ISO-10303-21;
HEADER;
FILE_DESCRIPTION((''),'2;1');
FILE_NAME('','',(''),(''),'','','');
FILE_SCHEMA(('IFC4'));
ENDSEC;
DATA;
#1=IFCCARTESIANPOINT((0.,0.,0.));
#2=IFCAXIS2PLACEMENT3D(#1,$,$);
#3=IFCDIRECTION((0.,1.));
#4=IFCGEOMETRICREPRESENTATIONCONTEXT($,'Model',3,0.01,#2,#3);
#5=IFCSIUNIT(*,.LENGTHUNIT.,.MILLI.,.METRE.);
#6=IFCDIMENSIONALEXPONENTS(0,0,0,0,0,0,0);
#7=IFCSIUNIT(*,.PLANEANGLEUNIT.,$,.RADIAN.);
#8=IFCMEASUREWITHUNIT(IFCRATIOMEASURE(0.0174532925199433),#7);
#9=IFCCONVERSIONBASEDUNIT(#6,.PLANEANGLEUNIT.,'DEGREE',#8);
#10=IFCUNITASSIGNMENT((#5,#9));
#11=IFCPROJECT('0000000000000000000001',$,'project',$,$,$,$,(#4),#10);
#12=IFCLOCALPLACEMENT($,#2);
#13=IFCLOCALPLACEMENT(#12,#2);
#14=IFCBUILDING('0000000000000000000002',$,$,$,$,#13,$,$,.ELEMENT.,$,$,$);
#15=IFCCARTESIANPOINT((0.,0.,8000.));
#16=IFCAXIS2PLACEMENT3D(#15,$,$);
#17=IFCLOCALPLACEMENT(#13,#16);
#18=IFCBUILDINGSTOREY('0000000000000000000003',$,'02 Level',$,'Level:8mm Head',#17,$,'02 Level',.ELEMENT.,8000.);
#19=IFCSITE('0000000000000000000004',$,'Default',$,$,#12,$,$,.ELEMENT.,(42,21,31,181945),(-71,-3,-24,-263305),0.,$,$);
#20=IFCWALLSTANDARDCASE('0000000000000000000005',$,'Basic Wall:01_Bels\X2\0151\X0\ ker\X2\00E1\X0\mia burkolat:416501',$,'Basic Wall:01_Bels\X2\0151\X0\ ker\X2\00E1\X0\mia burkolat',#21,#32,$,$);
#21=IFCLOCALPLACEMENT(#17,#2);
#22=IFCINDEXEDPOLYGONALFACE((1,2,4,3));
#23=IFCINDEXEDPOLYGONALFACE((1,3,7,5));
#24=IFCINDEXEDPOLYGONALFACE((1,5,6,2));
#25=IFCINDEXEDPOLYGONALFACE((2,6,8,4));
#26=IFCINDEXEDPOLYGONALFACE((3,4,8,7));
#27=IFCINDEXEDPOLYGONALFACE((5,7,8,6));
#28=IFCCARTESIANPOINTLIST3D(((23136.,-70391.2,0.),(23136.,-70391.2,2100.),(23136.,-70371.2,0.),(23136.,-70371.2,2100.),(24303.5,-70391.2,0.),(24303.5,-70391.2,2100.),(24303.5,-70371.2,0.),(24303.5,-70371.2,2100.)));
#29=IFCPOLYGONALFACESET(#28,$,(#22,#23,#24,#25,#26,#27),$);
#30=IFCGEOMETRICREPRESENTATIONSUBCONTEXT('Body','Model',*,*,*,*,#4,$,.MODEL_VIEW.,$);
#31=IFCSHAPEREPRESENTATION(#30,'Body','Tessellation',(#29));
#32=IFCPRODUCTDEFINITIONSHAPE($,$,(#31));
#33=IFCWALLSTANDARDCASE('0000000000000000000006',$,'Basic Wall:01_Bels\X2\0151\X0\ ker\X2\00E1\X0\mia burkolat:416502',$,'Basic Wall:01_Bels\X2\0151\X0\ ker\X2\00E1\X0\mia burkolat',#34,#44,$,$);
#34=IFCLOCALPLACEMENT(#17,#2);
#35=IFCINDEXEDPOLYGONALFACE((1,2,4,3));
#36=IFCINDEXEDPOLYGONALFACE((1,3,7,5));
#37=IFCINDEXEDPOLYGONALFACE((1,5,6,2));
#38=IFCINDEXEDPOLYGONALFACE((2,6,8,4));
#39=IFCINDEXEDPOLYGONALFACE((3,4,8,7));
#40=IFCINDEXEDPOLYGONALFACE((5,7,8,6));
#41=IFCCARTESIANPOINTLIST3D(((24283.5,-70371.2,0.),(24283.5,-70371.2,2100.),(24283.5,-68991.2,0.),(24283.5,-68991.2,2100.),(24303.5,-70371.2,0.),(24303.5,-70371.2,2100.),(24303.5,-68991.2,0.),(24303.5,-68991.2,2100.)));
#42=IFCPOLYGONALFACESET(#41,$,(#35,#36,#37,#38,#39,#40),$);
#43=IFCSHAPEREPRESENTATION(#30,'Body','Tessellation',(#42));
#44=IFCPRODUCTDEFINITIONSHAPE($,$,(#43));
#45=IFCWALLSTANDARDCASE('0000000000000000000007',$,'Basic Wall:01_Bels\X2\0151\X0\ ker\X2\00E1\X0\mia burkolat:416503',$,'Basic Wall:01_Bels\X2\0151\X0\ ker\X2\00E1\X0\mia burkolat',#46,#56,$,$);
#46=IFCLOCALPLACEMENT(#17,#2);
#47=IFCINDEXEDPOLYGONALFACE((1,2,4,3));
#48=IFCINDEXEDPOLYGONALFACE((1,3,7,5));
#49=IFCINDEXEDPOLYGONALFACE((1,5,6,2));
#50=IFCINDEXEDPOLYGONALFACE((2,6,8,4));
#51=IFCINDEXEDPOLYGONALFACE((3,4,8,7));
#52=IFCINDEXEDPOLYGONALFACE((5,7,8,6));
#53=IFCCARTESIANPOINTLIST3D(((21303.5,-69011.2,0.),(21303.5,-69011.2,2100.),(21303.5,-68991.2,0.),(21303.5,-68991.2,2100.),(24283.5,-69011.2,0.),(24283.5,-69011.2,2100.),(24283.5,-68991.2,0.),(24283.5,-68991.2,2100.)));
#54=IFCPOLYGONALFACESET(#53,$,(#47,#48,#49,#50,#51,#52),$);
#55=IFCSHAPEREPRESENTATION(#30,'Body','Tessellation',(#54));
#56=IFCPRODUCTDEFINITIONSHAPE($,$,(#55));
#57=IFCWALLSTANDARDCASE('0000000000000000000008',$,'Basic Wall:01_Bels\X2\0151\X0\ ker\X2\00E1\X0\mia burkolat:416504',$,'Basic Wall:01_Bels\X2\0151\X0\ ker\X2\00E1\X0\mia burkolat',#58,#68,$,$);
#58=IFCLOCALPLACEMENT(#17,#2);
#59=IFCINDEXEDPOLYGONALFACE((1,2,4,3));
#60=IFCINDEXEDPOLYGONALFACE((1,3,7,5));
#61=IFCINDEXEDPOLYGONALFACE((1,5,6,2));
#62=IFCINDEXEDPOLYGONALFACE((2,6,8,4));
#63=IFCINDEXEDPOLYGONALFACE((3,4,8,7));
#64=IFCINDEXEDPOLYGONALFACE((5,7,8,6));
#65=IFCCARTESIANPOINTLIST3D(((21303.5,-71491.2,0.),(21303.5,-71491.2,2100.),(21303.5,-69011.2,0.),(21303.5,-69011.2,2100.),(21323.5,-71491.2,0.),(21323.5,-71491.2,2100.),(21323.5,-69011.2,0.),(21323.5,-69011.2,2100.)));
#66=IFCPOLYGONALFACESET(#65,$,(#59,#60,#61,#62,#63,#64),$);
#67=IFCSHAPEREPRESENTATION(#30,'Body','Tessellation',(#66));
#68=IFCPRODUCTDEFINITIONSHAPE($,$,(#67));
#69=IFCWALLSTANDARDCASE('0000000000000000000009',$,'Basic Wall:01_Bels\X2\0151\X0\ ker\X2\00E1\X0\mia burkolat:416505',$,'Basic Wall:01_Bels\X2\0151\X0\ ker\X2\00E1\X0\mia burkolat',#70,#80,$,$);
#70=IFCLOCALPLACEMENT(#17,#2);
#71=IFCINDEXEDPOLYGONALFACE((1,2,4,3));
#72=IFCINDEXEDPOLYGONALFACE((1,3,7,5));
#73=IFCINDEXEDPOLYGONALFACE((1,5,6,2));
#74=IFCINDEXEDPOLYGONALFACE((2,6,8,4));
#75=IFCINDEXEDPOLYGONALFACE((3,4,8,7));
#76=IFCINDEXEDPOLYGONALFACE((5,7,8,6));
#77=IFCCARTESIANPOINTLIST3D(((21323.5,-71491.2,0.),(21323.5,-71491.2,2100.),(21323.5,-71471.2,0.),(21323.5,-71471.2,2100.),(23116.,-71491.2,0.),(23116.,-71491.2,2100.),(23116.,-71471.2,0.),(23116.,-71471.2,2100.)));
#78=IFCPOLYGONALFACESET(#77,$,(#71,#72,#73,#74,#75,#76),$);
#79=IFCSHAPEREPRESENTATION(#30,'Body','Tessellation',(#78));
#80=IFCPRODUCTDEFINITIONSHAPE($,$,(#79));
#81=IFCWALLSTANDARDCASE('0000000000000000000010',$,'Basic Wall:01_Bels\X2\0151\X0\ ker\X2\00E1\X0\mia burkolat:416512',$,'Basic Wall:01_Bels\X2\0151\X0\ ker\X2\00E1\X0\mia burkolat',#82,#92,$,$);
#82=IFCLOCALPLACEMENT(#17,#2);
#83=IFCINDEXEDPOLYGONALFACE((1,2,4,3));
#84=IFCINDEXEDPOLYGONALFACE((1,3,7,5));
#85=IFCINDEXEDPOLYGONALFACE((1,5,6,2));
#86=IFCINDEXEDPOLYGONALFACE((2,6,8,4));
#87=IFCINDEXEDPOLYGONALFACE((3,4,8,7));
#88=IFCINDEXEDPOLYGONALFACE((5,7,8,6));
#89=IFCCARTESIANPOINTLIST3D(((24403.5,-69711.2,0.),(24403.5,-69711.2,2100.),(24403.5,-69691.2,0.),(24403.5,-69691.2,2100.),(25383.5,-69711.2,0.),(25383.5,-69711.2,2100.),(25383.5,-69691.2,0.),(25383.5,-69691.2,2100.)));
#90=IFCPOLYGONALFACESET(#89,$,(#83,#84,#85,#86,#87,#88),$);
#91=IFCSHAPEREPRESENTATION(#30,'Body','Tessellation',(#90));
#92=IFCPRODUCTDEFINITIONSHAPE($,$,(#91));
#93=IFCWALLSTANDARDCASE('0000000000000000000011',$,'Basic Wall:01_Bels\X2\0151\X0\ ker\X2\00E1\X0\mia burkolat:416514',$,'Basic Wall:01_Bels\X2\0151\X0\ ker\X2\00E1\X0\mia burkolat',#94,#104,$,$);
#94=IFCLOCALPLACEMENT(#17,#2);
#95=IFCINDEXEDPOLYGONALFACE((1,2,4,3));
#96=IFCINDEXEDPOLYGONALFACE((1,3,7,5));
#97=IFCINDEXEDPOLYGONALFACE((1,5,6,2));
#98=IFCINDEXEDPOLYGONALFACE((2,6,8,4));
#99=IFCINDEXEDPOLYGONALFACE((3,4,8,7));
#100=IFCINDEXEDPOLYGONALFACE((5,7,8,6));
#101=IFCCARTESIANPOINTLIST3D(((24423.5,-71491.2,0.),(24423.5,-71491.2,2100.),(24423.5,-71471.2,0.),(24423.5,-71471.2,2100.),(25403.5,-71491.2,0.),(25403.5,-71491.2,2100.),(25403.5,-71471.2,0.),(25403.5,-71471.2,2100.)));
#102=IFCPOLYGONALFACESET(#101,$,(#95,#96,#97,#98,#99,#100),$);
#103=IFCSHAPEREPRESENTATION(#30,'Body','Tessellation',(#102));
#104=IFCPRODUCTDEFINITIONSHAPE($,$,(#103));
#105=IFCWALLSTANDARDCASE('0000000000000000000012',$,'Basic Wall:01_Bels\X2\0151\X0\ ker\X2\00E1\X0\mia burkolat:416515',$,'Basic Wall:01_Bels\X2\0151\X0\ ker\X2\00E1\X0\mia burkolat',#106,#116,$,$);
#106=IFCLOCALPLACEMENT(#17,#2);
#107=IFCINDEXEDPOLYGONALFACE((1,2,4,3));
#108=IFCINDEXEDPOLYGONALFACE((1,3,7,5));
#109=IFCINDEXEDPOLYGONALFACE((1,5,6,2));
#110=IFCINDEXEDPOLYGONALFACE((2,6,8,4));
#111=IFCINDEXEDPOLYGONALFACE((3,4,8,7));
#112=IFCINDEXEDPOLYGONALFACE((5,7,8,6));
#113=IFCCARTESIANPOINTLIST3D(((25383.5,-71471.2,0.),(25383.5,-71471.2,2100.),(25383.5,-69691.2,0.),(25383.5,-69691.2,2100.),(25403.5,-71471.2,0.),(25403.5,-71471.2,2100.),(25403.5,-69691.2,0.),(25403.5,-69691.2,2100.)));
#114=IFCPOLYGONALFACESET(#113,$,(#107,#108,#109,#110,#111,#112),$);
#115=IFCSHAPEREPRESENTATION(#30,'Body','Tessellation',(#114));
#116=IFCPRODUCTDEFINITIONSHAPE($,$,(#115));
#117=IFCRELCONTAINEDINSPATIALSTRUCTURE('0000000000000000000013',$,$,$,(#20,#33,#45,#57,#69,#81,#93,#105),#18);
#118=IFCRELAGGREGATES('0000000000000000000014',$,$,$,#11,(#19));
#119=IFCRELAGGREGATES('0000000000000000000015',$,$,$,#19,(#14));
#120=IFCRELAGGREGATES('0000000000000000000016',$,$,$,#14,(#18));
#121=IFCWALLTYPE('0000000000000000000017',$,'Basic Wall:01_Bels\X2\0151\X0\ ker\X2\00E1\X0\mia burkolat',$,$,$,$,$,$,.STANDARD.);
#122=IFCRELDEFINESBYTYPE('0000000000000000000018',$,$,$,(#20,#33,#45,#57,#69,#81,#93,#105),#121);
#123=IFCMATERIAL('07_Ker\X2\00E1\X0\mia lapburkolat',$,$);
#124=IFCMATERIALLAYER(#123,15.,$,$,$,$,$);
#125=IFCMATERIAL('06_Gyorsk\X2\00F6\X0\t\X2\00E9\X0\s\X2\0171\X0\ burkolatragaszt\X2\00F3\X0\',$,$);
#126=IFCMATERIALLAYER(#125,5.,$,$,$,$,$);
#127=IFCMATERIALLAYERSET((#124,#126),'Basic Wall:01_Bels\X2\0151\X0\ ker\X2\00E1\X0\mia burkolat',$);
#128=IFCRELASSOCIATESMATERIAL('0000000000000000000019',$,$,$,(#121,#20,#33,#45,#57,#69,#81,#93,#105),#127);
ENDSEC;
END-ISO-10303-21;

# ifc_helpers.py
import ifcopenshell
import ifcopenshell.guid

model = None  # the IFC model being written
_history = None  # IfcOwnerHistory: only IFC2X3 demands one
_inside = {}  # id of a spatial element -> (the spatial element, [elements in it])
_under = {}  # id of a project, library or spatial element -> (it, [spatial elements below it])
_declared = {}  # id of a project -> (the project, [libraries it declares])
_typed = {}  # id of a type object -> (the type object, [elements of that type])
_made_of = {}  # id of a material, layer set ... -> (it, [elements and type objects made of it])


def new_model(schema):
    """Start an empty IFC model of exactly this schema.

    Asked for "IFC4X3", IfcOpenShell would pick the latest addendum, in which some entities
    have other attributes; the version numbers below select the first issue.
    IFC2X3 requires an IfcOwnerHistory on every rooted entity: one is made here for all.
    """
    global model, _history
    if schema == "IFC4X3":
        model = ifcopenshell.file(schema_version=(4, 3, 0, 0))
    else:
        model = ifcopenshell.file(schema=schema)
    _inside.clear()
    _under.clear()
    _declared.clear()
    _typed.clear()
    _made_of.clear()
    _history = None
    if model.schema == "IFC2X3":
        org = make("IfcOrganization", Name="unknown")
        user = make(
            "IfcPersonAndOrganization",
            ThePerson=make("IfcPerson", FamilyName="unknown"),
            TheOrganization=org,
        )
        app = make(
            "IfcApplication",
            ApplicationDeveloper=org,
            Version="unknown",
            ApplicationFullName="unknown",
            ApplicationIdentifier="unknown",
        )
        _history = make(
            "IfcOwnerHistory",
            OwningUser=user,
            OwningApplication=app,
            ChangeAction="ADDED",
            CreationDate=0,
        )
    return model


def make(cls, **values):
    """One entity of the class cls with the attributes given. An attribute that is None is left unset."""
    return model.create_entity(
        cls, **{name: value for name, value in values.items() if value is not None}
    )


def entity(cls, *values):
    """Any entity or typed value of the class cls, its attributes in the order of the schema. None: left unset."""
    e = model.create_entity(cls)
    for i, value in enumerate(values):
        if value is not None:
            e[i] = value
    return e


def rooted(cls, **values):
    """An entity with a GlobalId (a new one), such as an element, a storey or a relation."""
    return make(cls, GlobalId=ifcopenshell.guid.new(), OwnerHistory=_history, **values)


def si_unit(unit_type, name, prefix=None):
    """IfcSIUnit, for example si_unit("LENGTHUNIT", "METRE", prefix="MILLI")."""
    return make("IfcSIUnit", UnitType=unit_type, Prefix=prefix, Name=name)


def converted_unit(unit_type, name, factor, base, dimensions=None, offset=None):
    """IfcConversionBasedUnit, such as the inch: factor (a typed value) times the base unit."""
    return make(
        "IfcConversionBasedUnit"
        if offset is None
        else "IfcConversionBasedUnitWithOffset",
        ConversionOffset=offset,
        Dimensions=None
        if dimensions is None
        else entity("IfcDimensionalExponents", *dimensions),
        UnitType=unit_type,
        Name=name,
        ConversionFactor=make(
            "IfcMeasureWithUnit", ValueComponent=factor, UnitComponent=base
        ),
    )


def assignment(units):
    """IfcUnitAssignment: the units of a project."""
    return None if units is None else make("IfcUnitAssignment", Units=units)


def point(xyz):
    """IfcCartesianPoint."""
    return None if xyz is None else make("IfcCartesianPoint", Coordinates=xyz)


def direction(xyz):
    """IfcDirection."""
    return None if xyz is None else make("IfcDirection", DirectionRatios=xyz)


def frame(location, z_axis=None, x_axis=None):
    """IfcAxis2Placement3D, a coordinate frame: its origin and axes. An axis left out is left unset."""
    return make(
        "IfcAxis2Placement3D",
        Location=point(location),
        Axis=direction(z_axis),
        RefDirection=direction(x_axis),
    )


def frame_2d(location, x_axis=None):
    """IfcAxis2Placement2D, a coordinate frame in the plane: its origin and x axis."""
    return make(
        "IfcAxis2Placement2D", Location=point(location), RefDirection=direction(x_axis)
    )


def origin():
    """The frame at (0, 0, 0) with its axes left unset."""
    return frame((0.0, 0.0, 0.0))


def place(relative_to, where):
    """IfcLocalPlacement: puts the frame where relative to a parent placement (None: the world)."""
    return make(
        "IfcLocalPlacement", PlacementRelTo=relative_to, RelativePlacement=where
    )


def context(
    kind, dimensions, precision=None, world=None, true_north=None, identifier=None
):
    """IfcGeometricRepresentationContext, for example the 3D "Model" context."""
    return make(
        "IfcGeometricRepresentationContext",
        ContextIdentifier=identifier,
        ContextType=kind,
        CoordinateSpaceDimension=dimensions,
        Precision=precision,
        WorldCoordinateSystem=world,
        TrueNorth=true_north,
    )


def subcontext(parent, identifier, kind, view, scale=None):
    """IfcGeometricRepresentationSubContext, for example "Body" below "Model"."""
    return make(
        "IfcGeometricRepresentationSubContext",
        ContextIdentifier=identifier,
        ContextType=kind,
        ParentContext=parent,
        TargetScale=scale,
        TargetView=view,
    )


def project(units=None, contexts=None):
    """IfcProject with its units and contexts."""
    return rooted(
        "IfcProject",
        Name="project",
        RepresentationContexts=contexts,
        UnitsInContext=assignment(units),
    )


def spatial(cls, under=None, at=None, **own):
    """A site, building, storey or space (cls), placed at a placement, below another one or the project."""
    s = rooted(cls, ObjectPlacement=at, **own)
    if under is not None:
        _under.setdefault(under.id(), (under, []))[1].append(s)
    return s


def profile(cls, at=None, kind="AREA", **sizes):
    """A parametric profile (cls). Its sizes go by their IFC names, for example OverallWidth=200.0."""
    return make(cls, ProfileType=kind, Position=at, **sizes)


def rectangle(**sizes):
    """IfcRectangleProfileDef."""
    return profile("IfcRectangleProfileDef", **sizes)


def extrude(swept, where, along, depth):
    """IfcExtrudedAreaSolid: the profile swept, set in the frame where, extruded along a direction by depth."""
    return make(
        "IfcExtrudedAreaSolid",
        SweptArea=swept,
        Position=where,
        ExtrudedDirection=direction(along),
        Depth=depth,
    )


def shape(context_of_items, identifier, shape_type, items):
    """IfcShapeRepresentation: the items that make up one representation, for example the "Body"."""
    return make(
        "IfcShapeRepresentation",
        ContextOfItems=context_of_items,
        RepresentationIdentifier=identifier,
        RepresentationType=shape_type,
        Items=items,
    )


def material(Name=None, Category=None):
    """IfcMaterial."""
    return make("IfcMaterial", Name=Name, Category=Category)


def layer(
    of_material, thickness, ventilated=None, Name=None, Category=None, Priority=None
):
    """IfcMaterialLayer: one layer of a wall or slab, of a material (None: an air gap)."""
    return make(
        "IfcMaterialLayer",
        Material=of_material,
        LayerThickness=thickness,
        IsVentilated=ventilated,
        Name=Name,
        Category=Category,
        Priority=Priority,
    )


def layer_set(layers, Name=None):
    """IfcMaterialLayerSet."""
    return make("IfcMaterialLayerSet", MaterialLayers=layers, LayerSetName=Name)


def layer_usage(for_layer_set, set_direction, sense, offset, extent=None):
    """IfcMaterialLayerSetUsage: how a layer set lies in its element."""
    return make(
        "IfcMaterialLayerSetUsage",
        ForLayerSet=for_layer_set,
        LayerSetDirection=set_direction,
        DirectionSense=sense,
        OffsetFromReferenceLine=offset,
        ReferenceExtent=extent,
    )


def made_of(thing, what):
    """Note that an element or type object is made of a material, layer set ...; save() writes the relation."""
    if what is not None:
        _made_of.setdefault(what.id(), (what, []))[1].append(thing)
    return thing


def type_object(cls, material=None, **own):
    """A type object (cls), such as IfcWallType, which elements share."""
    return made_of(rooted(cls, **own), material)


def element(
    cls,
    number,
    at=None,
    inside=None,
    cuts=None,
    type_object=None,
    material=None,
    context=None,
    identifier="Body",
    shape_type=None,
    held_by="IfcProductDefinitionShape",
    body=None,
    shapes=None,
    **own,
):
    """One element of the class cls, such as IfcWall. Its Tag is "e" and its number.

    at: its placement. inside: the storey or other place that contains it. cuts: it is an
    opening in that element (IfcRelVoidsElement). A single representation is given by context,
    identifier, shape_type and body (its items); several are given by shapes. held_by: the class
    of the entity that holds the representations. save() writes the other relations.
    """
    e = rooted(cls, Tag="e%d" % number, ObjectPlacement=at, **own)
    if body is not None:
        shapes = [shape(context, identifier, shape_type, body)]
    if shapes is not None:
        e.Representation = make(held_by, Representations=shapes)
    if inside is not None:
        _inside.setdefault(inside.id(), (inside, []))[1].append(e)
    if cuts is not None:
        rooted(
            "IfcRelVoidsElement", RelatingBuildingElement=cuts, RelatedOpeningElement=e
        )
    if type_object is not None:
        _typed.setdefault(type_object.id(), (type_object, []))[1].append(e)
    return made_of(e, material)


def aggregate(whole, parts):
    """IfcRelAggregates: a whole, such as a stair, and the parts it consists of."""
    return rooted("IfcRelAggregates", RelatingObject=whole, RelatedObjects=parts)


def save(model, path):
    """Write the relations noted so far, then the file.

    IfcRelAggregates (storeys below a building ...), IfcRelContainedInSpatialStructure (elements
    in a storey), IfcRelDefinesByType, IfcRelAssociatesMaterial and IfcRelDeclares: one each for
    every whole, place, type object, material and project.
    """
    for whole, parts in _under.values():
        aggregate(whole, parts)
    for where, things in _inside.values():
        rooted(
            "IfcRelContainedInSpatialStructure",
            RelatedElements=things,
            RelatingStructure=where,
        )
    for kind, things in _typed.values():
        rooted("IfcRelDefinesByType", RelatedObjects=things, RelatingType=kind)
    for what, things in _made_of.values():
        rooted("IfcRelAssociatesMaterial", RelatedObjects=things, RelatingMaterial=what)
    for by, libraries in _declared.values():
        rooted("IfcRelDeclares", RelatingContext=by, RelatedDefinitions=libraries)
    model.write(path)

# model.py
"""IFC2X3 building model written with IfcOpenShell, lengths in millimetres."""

from ifc_helpers import new_model, entity, si_unit, converted_unit, direction, frame, frame_2d, origin, place, context, subcontext, project, spatial, rectangle, extrude, material, layer, layer_set, layer_usage, type_object, element, save


model = new_model("IFC2X3")

# Units and contexts
model_context = context("Model", 3, precision=0.01, world=origin(), true_north=direction((0.0, 1.0)))
body_context = subcontext(model_context, "Body", "Model", "MODEL_VIEW")
ifc_project = project(units=[si_unit("LENGTHUNIT", "METRE", prefix="MILLI"), converted_unit("PLANEANGLEUNIT", "DEGREE", entity("IfcRatioMeasure", 0.0174532925199433), si_unit("PLANEANGLEUNIT", "RADIAN"), dimensions=[0, 0, 0, 0, 0, 0, 0])], contexts=[model_context])

# Site, building, storey
site_placement = place(None, origin())
site = spatial("IfcSite", under=ifc_project, at=site_placement, Name="Default", CompositionType="ELEMENT", RefLatitude=(42, 21, 31, 181945), RefLongitude=(-71, -3, -24, -263305), RefElevation=0.0)
building_placement = place(site_placement, origin())
building = spatial("IfcBuilding", under=site, at=building_placement, CompositionType="ELEMENT")
storey_placement = place(building_placement, frame((0.0, 0.0, 8000.0)))
storey = spatial("IfcBuildingStorey", under=building, at=storey_placement, Name="02 Level", ObjectType="Level:8mm Head", LongName="02 Level", CompositionType="ELEMENT", Elevation=8000.0)

# Shared definitions
ifc_material_1 = material(Name="07_Kerámia lapburkolat")
ifc_layer_1 = layer(ifc_material_1, 15.0)
ifc_material_2 = material(Name="06_Gyorskötésű burkolatragasztó")
ifc_layer_2 = layer(ifc_material_2, 5.0)
ifc_layer_set_1 = layer_set([ifc_layer_1, ifc_layer_2], Name="Basic Wall:01_Belső kerámia burkolat")
wall_type_1 = type_object("IfcWallType", Name="Basic Wall:01_Belső kerámia burkolat", PredefinedType="STANDARD", material=ifc_layer_set_1)

# Walls
ifc_layer_usage_1 = layer_usage(ifc_layer_set_1, "AXIS2", "NEGATIVE", 10.0)
wall_1_placement = place(storey_placement, frame((23136.0, -70381.2, 0.0)))
element("IfcWallStandardCase", 1, at=wall_1_placement, inside=storey, type_object=wall_type_1, material=ifc_layer_usage_1, Name="Basic Wall:01_Belső kerámia burkolat:416501", ObjectType="Basic Wall:01_Belső kerámia burkolat", context=body_context, shape_type="SweptSolid", body=[
    extrude(rectangle(XDim=1167.5, YDim=20.0, at=frame_2d((583.7, 0.0), x_axis=(-1.0, 0.0))), origin(), (0.0, 0.0, 1.0), 2100.0),
])
ifc_layer_usage_2 = layer_usage(ifc_layer_set_1, "AXIS2", "NEGATIVE", 10.0)
wall_2_placement = place(storey_placement, frame((24293.5, -70371.2, 0.0), z_axis=(0.0, 0.0, 1.0), x_axis=(0.0, 1.0, 0.0)))
element("IfcWallStandardCase", 2, at=wall_2_placement, inside=storey, type_object=wall_type_1, material=ifc_layer_usage_2, Name="Basic Wall:01_Belső kerámia burkolat:416502", ObjectType="Basic Wall:01_Belső kerámia burkolat", context=body_context, shape_type="SweptSolid", body=[
    extrude(rectangle(XDim=1380.0, YDim=20.0, at=frame_2d((690.0, 0.0), x_axis=(-1.0, 0.0))), origin(), (0.0, 0.0, 1.0), 2100.0),
])
ifc_layer_usage_3 = layer_usage(ifc_layer_set_1, "AXIS2", "NEGATIVE", 10.0)
wall_3_placement = place(storey_placement, frame((24283.5, -69001.2, 0.0), z_axis=(0.0, 0.0, 1.0), x_axis=(-1.0, 0.0, 0.0)))
element("IfcWallStandardCase", 3, at=wall_3_placement, inside=storey, type_object=wall_type_1, material=ifc_layer_usage_3, Name="Basic Wall:01_Belső kerámia burkolat:416503", ObjectType="Basic Wall:01_Belső kerámia burkolat", context=body_context, shape_type="SweptSolid", body=[
    extrude(rectangle(XDim=2980.0, YDim=20.0, at=frame_2d((1490.0, 0.0), x_axis=(-1.0, 0.0))), origin(), (0.0, 0.0, 1.0), 2100.0),
])
ifc_layer_usage_4 = layer_usage(ifc_layer_set_1, "AXIS2", "NEGATIVE", 10.0)
wall_4_placement = place(storey_placement, frame((21313.5, -69011.2, 0.0), z_axis=(0.0, 0.0, 1.0), x_axis=(0.0, -1.0, 0.0)))
element("IfcWallStandardCase", 4, at=wall_4_placement, inside=storey, type_object=wall_type_1, material=ifc_layer_usage_4, Name="Basic Wall:01_Belső kerámia burkolat:416504", ObjectType="Basic Wall:01_Belső kerámia burkolat", context=body_context, shape_type="SweptSolid", body=[
    extrude(rectangle(XDim=2480.0, YDim=20.0, at=frame_2d((1240.0, 0.0), x_axis=(-1.0, 0.0))), origin(), (0.0, 0.0, 1.0), 2100.0),
])
ifc_layer_usage_5 = layer_usage(ifc_layer_set_1, "AXIS2", "NEGATIVE", 10.0)
wall_5_placement = place(storey_placement, frame((21323.5, -71481.2, 0.0)))
element("IfcWallStandardCase", 5, at=wall_5_placement, inside=storey, type_object=wall_type_1, material=ifc_layer_usage_5, Name="Basic Wall:01_Belső kerámia burkolat:416505", ObjectType="Basic Wall:01_Belső kerámia burkolat", context=body_context, shape_type="SweptSolid", body=[
    extrude(rectangle(XDim=1792.5, YDim=20.0, at=frame_2d((896.3, 0.0), x_axis=(-1.0, 0.0))), origin(), (0.0, 0.0, 1.0), 2100.0),
])
ifc_layer_usage_6 = layer_usage(ifc_layer_set_1, "AXIS2", "POSITIVE", -10.0)
wall_6_placement = place(storey_placement, frame((24403.5, -69701.2, 0.0)))
element("IfcWallStandardCase", 6, at=wall_6_placement, inside=storey, type_object=wall_type_1, material=ifc_layer_usage_6, Name="Basic Wall:01_Belső kerámia burkolat:416512", ObjectType="Basic Wall:01_Belső kerámia burkolat", context=body_context, shape_type="SweptSolid", body=[
    extrude(rectangle(XDim=980.0, YDim=20.0, at=frame_2d((490.0, 0.0), x_axis=(-1.0, 0.0))), origin(), (0.0, 0.0, 1.0), 2100.0),
])

# Walls
ifc_layer_usage_7 = layer_usage(ifc_layer_set_1, "AXIS2", "POSITIVE", -10.0)
wall_7_placement = place(storey_placement, frame((25403.5, -71481.2, 0.0), z_axis=(0.0, 0.0, 1.0), x_axis=(-1.0, 0.0, 0.0)))
element("IfcWallStandardCase", 7, at=wall_7_placement, inside=storey, type_object=wall_type_1, material=ifc_layer_usage_7, Name="Basic Wall:01_Belső kerámia burkolat:416514", ObjectType="Basic Wall:01_Belső kerámia burkolat", context=body_context, shape_type="SweptSolid", body=[
    extrude(rectangle(XDim=980.0, YDim=20.0, at=frame_2d((490.0, 0.0), x_axis=(-1.0, 0.0))), origin(), (0.0, 0.0, 1.0), 2100.0),
])
ifc_layer_usage_8 = layer_usage(ifc_layer_set_1, "AXIS2", "POSITIVE", -10.0)
wall_8_placement = place(storey_placement, frame((25393.5, -69691.2, 0.0), z_axis=(0.0, 0.0, 1.0), x_axis=(0.0, -1.0, 0.0)))
element("IfcWallStandardCase", 8, at=wall_8_placement, inside=storey, type_object=wall_type_1, material=ifc_layer_usage_8, Name="Basic Wall:01_Belső kerámia burkolat:416515", ObjectType="Basic Wall:01_Belső kerámia burkolat", context=body_context, shape_type="SweptSolid", body=[
    extrude(rectangle(XDim=1780.0, YDim=20.0, at=frame_2d((890.0, 0.0), x_axis=(-1.0, 0.0))), origin(), (0.0, 0.0, 1.0), 2100.0),
])

save(model, "model.ifc")
